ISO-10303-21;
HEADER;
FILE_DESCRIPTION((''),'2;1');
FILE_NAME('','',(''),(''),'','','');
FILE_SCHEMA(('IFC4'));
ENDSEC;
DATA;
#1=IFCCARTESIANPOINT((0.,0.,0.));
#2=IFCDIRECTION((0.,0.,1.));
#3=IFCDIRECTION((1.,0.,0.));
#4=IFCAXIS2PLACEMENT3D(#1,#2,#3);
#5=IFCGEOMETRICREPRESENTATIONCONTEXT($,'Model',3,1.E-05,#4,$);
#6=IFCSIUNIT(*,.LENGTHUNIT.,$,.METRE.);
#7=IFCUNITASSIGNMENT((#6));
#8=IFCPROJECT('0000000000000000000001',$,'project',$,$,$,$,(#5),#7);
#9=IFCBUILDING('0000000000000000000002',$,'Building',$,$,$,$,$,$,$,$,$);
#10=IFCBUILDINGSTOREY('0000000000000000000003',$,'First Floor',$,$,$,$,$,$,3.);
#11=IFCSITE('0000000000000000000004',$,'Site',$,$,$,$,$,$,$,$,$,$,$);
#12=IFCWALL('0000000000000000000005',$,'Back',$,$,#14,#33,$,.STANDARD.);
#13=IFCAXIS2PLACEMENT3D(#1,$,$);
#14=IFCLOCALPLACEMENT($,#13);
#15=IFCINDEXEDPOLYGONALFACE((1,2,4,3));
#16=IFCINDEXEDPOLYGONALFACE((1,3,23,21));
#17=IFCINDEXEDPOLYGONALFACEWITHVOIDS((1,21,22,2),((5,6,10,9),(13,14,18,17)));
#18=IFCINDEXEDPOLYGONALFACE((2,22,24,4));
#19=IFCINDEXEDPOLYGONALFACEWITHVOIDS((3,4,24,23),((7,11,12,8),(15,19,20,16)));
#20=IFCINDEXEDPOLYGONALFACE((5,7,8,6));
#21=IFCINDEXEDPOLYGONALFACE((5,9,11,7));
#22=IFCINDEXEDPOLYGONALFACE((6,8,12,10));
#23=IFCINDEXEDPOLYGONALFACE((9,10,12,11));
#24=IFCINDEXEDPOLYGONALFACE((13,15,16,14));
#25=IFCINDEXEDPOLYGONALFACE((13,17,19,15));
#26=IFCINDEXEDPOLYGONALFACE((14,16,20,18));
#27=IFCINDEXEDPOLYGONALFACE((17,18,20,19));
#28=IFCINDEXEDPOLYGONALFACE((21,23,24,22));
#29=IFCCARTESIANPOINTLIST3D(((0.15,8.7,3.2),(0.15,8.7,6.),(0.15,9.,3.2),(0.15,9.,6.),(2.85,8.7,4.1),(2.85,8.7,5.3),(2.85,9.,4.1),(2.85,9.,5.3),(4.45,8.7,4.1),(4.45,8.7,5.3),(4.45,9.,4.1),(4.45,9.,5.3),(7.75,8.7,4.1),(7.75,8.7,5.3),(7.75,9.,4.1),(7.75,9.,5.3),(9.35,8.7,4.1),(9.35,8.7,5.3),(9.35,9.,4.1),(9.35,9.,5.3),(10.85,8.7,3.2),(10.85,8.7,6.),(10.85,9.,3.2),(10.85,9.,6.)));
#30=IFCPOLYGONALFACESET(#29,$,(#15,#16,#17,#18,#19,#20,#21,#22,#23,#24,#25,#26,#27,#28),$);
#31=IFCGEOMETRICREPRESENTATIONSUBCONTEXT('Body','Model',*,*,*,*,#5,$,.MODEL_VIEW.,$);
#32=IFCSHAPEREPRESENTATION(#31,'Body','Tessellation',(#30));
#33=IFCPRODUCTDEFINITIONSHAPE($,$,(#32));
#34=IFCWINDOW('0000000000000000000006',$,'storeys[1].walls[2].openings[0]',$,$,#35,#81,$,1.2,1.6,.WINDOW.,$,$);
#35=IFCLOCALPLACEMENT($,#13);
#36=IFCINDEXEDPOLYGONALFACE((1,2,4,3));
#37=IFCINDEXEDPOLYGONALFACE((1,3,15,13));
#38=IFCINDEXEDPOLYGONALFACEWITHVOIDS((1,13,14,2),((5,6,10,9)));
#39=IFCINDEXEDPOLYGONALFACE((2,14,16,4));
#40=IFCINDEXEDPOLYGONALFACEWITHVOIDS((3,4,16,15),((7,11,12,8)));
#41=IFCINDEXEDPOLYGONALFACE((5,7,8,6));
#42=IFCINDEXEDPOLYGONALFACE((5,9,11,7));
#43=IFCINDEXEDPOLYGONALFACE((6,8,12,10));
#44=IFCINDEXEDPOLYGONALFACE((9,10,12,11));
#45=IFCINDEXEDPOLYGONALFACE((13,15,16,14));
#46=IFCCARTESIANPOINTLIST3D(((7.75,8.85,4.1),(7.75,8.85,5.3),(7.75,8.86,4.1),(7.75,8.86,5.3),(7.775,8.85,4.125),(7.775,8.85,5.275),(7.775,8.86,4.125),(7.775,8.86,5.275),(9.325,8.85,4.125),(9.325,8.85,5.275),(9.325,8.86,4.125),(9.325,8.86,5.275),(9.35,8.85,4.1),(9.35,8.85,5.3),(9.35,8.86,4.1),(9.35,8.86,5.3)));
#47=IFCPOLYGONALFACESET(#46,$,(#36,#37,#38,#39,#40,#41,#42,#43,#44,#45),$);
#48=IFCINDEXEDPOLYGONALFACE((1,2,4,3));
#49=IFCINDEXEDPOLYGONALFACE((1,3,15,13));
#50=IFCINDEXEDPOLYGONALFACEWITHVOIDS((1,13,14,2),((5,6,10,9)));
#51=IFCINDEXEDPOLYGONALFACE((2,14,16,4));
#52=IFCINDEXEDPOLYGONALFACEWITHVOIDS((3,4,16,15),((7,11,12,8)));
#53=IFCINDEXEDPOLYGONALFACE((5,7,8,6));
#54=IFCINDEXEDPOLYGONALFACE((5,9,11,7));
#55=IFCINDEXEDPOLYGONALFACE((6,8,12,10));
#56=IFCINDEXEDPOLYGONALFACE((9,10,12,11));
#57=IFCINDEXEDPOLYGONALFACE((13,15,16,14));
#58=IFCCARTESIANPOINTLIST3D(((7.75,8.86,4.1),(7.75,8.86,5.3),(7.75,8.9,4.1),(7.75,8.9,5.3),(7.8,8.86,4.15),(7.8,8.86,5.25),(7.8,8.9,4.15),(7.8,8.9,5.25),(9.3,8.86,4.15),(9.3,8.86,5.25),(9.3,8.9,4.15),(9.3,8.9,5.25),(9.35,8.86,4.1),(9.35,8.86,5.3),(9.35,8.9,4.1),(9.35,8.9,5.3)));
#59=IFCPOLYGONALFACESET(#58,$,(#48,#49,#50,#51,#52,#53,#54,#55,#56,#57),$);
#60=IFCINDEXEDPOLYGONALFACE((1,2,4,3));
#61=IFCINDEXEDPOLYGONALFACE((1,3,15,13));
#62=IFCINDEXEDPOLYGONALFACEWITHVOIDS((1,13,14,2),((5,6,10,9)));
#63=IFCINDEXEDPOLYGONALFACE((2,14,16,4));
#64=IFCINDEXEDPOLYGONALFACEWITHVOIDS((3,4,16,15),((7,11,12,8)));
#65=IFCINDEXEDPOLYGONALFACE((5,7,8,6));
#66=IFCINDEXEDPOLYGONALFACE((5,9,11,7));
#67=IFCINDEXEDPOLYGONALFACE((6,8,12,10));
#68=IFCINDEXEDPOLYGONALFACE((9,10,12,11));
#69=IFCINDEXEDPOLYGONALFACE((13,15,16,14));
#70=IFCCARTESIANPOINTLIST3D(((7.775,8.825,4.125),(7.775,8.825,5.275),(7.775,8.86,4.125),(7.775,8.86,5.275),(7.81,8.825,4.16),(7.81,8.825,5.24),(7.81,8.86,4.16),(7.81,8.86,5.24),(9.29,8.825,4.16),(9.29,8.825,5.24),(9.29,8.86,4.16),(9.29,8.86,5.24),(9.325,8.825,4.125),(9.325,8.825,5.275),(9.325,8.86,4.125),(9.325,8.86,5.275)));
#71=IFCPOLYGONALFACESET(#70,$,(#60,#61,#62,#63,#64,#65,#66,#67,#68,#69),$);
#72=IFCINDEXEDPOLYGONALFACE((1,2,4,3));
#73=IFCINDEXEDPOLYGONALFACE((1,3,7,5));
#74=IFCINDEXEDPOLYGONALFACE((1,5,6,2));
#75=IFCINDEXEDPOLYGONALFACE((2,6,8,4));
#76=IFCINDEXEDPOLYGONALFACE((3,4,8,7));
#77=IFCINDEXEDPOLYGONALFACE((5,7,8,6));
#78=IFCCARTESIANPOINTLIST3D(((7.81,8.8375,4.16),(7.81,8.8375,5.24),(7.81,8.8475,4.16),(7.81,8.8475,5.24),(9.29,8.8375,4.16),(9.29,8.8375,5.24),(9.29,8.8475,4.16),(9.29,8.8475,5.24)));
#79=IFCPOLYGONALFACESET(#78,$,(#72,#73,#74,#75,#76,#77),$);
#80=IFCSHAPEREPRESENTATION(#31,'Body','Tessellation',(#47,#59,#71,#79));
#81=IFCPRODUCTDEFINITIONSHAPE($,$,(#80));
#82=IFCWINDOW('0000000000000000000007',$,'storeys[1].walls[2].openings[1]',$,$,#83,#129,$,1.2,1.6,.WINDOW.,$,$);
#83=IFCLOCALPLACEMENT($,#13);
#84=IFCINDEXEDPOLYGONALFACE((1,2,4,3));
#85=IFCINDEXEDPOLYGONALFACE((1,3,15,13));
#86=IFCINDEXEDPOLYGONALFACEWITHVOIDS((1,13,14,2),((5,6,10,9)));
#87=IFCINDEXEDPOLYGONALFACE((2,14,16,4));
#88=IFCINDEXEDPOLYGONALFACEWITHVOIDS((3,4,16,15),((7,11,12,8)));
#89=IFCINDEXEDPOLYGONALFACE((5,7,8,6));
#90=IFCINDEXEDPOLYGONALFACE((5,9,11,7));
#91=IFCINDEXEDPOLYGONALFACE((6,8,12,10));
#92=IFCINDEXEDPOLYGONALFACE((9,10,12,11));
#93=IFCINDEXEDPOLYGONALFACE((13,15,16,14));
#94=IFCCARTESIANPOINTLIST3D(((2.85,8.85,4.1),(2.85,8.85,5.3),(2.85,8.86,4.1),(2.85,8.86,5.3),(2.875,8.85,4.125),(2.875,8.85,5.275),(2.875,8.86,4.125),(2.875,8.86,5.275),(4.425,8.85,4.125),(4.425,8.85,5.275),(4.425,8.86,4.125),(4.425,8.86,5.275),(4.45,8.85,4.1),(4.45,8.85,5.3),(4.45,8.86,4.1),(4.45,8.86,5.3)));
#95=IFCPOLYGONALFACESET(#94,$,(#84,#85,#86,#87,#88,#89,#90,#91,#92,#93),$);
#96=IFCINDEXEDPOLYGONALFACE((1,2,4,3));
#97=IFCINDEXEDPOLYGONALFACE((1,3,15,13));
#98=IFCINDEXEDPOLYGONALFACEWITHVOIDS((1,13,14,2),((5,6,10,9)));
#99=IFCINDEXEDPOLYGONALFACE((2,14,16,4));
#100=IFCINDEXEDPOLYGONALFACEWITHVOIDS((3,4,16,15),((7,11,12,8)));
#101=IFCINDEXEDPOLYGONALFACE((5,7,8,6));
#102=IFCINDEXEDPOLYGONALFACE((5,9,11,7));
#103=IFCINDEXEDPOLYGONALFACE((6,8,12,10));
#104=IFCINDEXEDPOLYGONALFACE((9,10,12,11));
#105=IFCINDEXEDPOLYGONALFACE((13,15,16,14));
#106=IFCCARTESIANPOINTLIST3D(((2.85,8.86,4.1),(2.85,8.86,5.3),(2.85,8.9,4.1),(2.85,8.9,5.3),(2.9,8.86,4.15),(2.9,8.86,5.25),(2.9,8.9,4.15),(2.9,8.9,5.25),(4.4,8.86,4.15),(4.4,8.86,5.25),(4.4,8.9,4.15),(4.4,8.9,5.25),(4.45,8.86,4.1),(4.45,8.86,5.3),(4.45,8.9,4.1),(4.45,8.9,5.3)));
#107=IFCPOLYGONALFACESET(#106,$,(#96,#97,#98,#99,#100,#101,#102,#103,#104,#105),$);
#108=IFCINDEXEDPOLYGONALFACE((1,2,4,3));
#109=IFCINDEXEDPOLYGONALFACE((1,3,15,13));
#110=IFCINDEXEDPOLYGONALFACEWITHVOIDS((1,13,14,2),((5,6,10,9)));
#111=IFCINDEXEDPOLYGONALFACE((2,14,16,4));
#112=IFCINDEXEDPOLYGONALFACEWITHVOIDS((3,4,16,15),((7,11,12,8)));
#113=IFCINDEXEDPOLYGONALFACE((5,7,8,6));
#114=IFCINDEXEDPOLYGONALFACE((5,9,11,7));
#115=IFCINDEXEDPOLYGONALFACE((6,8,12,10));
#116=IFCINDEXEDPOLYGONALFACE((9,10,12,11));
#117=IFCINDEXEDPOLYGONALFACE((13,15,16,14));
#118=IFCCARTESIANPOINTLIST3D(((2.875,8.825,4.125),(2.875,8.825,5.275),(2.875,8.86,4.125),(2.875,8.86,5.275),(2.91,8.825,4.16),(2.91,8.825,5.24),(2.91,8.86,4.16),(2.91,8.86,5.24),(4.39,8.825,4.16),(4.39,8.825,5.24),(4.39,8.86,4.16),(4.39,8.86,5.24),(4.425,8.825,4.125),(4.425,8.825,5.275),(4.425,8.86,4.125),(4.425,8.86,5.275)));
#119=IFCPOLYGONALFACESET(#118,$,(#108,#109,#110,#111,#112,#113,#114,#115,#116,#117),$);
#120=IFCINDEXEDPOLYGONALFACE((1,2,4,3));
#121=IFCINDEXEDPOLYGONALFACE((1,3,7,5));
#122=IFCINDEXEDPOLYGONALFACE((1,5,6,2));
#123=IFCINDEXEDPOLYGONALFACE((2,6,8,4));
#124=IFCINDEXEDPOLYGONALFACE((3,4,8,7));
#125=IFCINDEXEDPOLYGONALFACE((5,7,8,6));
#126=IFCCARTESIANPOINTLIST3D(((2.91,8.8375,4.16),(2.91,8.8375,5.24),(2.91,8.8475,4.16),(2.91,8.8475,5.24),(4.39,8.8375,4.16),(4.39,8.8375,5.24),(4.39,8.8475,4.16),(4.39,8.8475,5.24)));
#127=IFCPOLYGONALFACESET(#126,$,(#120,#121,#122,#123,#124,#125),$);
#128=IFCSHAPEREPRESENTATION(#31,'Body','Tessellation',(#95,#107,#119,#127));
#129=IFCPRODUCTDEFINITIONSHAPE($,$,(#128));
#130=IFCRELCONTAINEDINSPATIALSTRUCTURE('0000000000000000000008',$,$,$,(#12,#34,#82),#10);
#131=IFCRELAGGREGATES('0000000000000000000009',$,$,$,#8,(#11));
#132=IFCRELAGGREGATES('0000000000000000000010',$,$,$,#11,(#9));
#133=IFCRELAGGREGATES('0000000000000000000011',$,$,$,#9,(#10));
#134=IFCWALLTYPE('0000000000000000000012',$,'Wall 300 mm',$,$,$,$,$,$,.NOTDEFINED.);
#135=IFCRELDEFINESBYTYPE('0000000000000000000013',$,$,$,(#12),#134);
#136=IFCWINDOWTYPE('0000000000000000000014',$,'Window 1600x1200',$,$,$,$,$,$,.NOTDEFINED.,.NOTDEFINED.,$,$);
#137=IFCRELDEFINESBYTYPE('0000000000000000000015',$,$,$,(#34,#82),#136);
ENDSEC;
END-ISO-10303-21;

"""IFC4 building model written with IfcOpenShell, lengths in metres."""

from ifc_helpers import new_model, si_unit, frame, origin_with_axes, place, context, subcontext, project, spatial, line, indexed_curve, outline, extrude, type_object, element, fill, save


model = new_model("IFC4")

# Units and contexts
model_context = context("Model", 3, precision=1e-05, world=origin_with_axes())
body_context = subcontext(model_context, "Body", "Model", "MODEL_VIEW")
ifc_project = project(units=[si_unit("LENGTHUNIT", "METRE")], contexts=[model_context])

# Site, building, storey
site = spatial("IfcSite", under=ifc_project, Name="Site")
building = spatial("IfcBuilding", under=site, Name="Building")
storey = spatial("IfcBuildingStorey", under=building, Name="First Floor", Elevation=3.0)

# Shared definitions
wall_type_1 = type_object("IfcWallType", Name="Wall 300 mm", PredefinedType="NOTDEFINED")

# Wall, openings, windows
wall_1_placement = place(None, frame((10.85, 8.85, 3.2), z_axis=(0.0, 0.0, 1.0), x_axis=(-1.0, 0.0, 0.0)))
wall_1 = element("IfcWall", 1, at=wall_1_placement, inside=storey, type_object=wall_type_1, Name="Back", PredefinedType="STANDARD", context=body_context, shape_type="SweptSolid", body=[
    extrude(outline(indexed_curve([(0.0, 0.0), (0.0, 0.3), (10.7, 0.3), (10.7, 0.0), (0.0, 0.0)], self_intersect=False)), frame((0.0, -0.15, 0.0), z_axis=(0.0, 0.0, 1.0), x_axis=(1.0, 0.0, 0.0)), (0.0, 0.0, 1.0), 2.8),
])
opening_1_placement = place(wall_1_placement, frame((1.5, -0.16, 0.9), z_axis=(0.0, 0.0, 1.0), x_axis=(1.0, 0.0, 0.0)))
opening_1 = element("IfcOpeningElement", 2, at=opening_1_placement, cuts=wall_1, context=body_context, shape_type="SweptSolid", body=[
    extrude(outline(indexed_curve([(0.0, 0.0), (0.0, 0.32), (1.6, 0.32), (1.6, 0.0), (0.0, 0.0)], self_intersect=False)), origin_with_axes(), (0.0, 0.0, 1.0), 1.2),
])
opening_2_placement = place(wall_1_placement, frame((6.4, -0.16, 0.9), z_axis=(0.0, 0.0, 1.0), x_axis=(1.0, 0.0, 0.0)))
opening_2 = element("IfcOpeningElement", 3, at=opening_2_placement, cuts=wall_1, context=body_context, shape_type="SweptSolid", body=[
    extrude(outline(indexed_curve([(0.0, 0.0), (0.0, 0.32), (1.6, 0.32), (1.6, 0.0), (0.0, 0.0)], self_intersect=False)), origin_with_axes(), (0.0, 0.0, 1.0), 1.2),
])
window_type_1 = type_object("IfcWindowType", Name="Window 1600x1200", PartitioningType="NOTDEFINED", PredefinedType="NOTDEFINED")
window_1_placement = place(None, frame((9.35, 8.95, 4.1), z_axis=(0.0, 0.0, 1.0), x_axis=(-1.0, 0.0, 0.0)))
window_1 = element("IfcWindow", 4, at=window_1_placement, inside=storey, type_object=window_type_1, Name="storeys[1].walls[2].openings[0]", OverallHeight=1.2, OverallWidth=1.6, PredefinedType="WINDOW", context=body_context, shape_type="SweptSolid", body=[
    extrude(outline(indexed_curve([(0.0, 0.0), (1.6, 0.0), (1.6, 1.2), (0.0, 1.2)], segments=[line(1, 2, 3, 4, 1)]), holes=[indexed_curve([(0.025, 0.025), (1.575, 0.025), (1.575, 1.175), (0.025, 1.175)], segments=[line(1, 2, 3, 4, 1)])]), frame((0.0, 0.09, 0.0), z_axis=(0.0, -1.0, 0.0), x_axis=(1.0, 0.0, 0.0)), (0.0, 0.0, -1.0), 0.01),
    extrude(outline(indexed_curve([(0.0, 0.0), (1.6, 0.0), (1.6, 1.2), (0.0, 1.2)], segments=[line(1, 2, 3, 4, 1)]), holes=[indexed_curve([(0.05, 0.05), (1.55, 0.05), (1.55, 1.15), (0.05, 1.15)], segments=[line(1, 2, 3, 4, 1)])]), frame((0.0, 0.05, 0.0), z_axis=(0.0, -1.0, 0.0), x_axis=(1.0, 0.0, 0.0)), (0.0, 0.0, -1.0), 0.04),
    extrude(outline(indexed_curve([(0.0, 0.0), (1.55, 0.0), (1.55, 1.15), (0.0, 1.15)], segments=[line(1, 2, 3, 4, 1)]), holes=[indexed_curve([(0.035, 0.035), (1.515, 0.035), (1.515, 1.115), (0.035, 1.115)], segments=[line(1, 2, 3, 4, 1)])]), frame((0.025, 0.09, 0.025), z_axis=(0.0, -1.0, 0.0), x_axis=(1.0, 0.0, 0.0)), (0.0, 0.0, -1.0), 0.035),
    extrude(outline(indexed_curve([(0.035, 0.035), (1.515, 0.035), (1.515, 1.115), (0.035, 1.115)], segments=[line(1, 2, 3, 4, 1)])), frame((0.025, 0.1025, 0.025), z_axis=(0.0, -1.0, 0.0), x_axis=(1.0, 0.0, 0.0)), (0.0, 0.0, -1.0), 0.01),
])
fill(opening_1, window_1)
window_2_placement = place(None, frame((4.45, 8.95, 4.1), z_axis=(0.0, 0.0, 1.0), x_axis=(-1.0, 0.0, 0.0)))
window_2 = element("IfcWindow", 5, at=window_2_placement, inside=storey, type_object=window_type_1, Name="storeys[1].walls[2].openings[1]", OverallHeight=1.2, OverallWidth=1.6, PredefinedType="WINDOW", context=body_context, shape_type="SweptSolid", body=[
    extrude(outline(indexed_curve([(0.0, 0.0), (1.6, 0.0), (1.6, 1.2), (0.0, 1.2)], segments=[line(1, 2, 3, 4, 1)]), holes=[indexed_curve([(0.025, 0.025), (1.575, 0.025), (1.575, 1.175), (0.025, 1.175)], segments=[line(1, 2, 3, 4, 1)])]), frame((0.0, 0.09, 0.0), z_axis=(0.0, -1.0, 0.0), x_axis=(1.0, 0.0, 0.0)), (0.0, 0.0, -1.0), 0.01),
    extrude(outline(indexed_curve([(0.0, 0.0), (1.6, 0.0), (1.6, 1.2), (0.0, 1.2)], segments=[line(1, 2, 3, 4, 1)]), holes=[indexed_curve([(0.05, 0.05), (1.55, 0.05), (1.55, 1.15), (0.05, 1.15)], segments=[line(1, 2, 3, 4, 1)])]), frame((0.0, 0.05, 0.0), z_axis=(0.0, -1.0, 0.0), x_axis=(1.0, 0.0, 0.0)), (0.0, 0.0, -1.0), 0.04),
    extrude(outline(indexed_curve([(0.0, 0.0), (1.55, 0.0), (1.55, 1.15), (0.0, 1.15)], segments=[line(1, 2, 3, 4, 1)]), holes=[indexed_curve([(0.035, 0.035), (1.515, 0.035), (1.515, 1.115), (0.035, 1.115)], segments=[line(1, 2, 3, 4, 1)])]), frame((0.025, 0.09, 0.025), z_axis=(0.0, -1.0, 0.0), x_axis=(1.0, 0.0, 0.0)), (0.0, 0.0, -1.0), 0.035),
    extrude(outline(indexed_curve([(0.035, 0.035), (1.515, 0.035), (1.515, 1.115), (0.035, 1.115)], segments=[line(1, 2, 3, 4, 1)])), frame((0.025, 0.1025, 0.025), z_axis=(0.0, -1.0, 0.0), x_axis=(1.0, 0.0, 0.0)), (0.0, 0.0, -1.0), 0.01),
])
fill(opening_2, window_2)

save(model, "model.ifc")
